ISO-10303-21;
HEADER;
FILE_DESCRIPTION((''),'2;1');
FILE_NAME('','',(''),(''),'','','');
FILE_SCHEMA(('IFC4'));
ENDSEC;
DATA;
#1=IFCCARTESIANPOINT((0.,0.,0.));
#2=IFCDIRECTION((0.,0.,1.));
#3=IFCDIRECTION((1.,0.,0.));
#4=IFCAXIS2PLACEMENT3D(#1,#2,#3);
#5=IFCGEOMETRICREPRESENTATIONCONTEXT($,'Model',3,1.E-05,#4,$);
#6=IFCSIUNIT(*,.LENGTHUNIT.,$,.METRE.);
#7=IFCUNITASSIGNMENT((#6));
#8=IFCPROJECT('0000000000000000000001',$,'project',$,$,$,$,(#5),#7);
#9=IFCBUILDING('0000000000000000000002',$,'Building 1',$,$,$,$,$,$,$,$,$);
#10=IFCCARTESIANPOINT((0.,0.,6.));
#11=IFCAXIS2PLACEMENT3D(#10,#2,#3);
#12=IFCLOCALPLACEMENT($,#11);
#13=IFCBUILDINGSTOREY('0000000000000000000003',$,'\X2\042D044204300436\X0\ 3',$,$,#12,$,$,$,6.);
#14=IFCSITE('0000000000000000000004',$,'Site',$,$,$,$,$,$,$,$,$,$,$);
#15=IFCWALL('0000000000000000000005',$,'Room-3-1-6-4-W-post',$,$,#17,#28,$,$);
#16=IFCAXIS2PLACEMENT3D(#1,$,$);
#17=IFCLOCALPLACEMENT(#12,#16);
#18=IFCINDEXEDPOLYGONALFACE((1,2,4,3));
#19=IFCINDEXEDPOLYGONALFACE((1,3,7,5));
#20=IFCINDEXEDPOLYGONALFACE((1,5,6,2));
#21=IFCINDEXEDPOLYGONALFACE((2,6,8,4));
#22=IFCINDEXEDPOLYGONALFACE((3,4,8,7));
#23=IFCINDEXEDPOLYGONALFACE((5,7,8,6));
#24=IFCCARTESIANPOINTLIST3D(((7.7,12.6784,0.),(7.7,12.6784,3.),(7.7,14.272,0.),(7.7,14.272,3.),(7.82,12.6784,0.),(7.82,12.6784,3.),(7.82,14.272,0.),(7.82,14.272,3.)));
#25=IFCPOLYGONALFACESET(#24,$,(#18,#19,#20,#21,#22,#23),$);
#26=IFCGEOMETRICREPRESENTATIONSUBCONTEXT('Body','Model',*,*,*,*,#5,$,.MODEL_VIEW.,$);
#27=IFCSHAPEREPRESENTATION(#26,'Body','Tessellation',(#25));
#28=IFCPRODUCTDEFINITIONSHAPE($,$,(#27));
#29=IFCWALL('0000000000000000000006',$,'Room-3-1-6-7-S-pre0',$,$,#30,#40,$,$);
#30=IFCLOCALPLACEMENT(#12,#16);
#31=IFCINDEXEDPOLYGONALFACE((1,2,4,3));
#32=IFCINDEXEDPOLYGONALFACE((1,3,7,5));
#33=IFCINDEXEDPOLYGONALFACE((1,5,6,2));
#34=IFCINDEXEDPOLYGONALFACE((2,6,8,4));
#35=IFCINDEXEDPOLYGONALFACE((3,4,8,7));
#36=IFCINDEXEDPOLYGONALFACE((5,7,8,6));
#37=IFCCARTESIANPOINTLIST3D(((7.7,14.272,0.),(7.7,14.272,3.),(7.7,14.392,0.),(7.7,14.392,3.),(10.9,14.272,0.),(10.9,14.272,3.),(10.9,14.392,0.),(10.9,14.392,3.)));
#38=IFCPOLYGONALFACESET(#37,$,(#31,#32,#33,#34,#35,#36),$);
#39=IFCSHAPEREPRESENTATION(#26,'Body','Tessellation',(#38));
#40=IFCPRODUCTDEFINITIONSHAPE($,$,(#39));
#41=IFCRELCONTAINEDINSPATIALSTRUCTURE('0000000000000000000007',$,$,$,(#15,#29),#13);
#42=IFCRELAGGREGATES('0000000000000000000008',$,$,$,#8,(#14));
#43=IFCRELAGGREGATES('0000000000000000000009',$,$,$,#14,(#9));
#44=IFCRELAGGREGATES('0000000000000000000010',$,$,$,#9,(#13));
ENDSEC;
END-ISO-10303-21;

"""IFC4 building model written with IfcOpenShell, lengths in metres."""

from ifc_helpers import new_model, si_unit, frame, origin_with_axes, place, context, subcontext, project, spatial, indexed_curve, outline, extrude, element, save


model = new_model("IFC4")

# Units and contexts
model_context = context("Model", 3, precision=1e-05, world=origin_with_axes())
body_context = subcontext(model_context, "Body", "Model", "MODEL_VIEW")
ifc_project = project(units=[si_unit("LENGTHUNIT", "METRE")], contexts=[model_context])

# Site, building, storey
site = spatial("IfcSite", under=ifc_project, Name="Site")
building = spatial("IfcBuilding", under=site, Name="Building 1")
storey_placement = place(None, frame((0.0, 0.0, 6.0), z_axis=(0.0, 0.0, 1.0), x_axis=(1.0, 0.0, 0.0)))
storey = spatial("IfcBuildingStorey", under=building, at=storey_placement, Name="Этаж 3", Elevation=6.0)

# Walls
wall_1_placement = place(storey_placement, frame((7.7, 14.272, 0.0), z_axis=(0.0, 0.0, 1.0), x_axis=(0.0, -1.0, 0.0)))
element("IfcWall", 1, at=wall_1_placement, inside=storey, Name="Room-3-1-6-4-W-post", context=body_context, shape_type="SweptSolid", body=[
    extrude(outline(indexed_curve([(0.0, 0.0), (0.0, 0.12), (1.5936, 0.12), (1.5936, 0.0), (0.0, 0.0)], self_intersect=False)), origin_with_axes(), (0.0, 0.0, 1.0), 3.0),
])
wall_2_placement = place(storey_placement, frame((7.7, 14.272, 0.0), z_axis=(0.0, 0.0, 1.0), x_axis=(1.0, 0.0, 0.0)))
element("IfcWall", 2, at=wall_2_placement, inside=storey, Name="Room-3-1-6-7-S-pre0", context=body_context, shape_type="SweptSolid", body=[
    extrude(outline(indexed_curve([(0.0, 0.0), (0.0, 0.12), (3.2, 0.12), (3.2, 0.0), (0.0, 0.0)], self_intersect=False)), origin_with_axes(), (0.0, 0.0, 1.0), 3.0),
])

save(model, "model.ifc")
